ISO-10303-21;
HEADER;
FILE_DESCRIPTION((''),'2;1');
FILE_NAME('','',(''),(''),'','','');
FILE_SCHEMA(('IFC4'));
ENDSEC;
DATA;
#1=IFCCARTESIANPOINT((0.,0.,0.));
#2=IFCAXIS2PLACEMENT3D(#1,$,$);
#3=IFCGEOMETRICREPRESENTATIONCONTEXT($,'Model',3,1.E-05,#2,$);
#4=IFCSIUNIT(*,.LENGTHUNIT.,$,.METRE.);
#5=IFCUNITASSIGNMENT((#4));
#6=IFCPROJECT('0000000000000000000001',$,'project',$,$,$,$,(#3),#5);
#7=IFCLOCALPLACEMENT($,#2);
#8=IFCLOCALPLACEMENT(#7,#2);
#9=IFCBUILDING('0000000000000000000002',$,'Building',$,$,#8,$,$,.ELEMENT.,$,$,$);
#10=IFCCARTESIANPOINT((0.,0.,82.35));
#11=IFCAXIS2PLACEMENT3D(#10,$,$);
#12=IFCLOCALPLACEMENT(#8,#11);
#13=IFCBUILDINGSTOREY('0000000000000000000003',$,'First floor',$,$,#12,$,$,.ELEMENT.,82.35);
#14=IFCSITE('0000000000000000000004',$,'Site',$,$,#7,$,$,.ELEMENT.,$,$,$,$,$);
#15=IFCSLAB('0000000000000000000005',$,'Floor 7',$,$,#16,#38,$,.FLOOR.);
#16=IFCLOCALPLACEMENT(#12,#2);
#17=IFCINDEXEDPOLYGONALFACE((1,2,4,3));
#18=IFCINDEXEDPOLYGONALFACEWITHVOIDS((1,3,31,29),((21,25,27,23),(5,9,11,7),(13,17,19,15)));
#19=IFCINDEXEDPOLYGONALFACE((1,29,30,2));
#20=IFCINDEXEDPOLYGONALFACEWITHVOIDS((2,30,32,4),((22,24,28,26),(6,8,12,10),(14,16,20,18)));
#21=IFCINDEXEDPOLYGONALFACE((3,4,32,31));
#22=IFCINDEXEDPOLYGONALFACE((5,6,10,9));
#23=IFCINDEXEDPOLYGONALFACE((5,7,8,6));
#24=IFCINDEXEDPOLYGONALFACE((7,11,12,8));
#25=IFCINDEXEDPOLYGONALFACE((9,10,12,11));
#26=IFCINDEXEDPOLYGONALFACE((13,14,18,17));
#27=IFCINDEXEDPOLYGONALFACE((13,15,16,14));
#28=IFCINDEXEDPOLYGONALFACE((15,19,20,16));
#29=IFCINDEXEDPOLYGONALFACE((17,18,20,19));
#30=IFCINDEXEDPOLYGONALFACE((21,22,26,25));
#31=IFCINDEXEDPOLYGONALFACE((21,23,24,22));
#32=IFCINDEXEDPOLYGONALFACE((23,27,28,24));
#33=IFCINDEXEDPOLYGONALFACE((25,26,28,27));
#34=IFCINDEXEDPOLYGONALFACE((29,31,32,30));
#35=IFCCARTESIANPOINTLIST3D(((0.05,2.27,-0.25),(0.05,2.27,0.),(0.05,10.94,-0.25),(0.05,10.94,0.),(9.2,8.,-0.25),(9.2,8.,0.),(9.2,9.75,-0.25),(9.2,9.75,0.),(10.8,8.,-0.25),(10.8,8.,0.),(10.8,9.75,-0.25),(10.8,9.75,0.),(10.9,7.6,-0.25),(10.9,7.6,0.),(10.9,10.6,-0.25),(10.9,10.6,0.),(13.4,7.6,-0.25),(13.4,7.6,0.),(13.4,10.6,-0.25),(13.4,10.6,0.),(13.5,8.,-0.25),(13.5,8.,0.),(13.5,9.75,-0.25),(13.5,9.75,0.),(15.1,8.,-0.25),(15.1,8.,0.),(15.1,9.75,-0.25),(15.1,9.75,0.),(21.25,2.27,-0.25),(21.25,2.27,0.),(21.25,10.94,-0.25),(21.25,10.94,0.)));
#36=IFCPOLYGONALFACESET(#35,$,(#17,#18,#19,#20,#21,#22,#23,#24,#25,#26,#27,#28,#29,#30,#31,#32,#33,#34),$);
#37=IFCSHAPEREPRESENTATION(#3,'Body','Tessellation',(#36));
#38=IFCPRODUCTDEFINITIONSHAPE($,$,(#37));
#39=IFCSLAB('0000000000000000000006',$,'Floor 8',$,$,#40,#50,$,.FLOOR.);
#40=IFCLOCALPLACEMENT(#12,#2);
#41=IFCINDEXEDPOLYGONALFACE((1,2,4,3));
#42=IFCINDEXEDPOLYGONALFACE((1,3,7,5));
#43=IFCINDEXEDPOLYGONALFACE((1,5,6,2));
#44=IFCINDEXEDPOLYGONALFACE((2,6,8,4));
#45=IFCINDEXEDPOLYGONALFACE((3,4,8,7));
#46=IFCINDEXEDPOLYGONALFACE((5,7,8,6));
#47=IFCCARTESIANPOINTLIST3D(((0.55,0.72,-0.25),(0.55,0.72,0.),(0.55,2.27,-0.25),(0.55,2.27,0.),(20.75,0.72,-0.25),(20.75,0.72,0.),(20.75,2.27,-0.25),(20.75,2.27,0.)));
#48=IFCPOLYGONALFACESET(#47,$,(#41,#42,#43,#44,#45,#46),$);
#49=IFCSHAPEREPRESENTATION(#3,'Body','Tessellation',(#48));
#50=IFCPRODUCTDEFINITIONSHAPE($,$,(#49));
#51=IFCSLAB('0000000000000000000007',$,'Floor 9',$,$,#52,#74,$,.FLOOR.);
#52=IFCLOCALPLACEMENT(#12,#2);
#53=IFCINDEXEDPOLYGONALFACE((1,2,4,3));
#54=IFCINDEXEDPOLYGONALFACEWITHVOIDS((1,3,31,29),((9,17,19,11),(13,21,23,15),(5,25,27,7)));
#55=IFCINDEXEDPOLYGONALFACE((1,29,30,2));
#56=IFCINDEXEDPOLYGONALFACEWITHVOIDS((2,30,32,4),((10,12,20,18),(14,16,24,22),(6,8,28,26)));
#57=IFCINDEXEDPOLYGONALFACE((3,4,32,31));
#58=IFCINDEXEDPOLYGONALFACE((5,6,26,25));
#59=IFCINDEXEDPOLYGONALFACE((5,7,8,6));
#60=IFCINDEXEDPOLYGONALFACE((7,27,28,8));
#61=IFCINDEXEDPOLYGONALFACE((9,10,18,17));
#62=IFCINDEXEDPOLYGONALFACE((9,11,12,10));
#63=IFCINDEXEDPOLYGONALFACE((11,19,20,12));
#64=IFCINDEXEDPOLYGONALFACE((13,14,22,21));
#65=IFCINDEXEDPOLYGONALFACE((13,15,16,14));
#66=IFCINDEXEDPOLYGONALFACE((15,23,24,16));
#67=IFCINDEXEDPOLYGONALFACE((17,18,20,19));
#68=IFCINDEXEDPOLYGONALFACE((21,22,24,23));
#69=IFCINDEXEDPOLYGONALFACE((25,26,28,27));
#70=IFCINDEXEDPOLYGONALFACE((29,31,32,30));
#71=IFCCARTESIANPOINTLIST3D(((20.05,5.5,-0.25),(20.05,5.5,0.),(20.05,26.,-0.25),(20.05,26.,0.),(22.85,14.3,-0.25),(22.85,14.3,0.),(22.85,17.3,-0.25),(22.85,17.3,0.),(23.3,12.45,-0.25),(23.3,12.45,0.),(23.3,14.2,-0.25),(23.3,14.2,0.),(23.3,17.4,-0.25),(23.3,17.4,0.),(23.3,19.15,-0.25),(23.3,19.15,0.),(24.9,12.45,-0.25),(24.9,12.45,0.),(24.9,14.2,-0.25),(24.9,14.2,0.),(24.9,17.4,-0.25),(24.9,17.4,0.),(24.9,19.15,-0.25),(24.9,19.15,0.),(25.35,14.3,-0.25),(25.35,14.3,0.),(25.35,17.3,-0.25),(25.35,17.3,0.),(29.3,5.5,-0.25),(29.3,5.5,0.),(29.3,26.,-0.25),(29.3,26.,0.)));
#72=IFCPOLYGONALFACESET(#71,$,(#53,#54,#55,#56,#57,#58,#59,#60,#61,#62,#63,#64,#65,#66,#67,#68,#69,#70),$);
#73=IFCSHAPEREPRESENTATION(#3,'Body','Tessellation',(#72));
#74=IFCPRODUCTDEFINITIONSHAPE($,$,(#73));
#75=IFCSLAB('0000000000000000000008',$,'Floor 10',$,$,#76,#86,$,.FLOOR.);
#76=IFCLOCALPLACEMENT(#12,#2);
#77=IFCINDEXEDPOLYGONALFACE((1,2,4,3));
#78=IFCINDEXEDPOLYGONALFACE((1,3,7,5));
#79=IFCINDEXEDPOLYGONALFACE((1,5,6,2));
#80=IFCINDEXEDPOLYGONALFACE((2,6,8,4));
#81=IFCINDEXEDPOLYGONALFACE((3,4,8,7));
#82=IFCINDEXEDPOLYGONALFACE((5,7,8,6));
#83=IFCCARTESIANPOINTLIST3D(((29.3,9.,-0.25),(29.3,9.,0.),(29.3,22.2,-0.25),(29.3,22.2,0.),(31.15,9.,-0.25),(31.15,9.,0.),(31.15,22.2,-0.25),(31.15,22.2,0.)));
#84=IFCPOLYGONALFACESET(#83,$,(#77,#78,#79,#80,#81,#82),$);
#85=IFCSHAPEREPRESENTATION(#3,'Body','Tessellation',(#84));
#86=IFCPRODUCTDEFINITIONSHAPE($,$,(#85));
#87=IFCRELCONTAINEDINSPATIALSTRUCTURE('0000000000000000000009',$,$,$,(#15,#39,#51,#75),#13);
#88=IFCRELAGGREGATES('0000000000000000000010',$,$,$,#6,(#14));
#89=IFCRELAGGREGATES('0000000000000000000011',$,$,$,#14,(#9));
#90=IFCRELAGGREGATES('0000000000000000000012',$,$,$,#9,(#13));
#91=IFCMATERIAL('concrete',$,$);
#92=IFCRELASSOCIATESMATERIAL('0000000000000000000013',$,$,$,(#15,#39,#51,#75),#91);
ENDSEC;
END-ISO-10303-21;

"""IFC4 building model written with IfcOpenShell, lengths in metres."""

from ifc_helpers import new_model, si_unit, frame, origin, place, context, project, spatial, polyline, outline, extrude, material, element, save


model = new_model("IFC4")

# Units and contexts
model_context = context("Model", 3, precision=1e-05, world=origin())
ifc_project = project(units=[si_unit("LENGTHUNIT", "METRE")], contexts=[model_context])

# Site, building, storey
site_placement = place(None, origin())
site = spatial("IfcSite", under=ifc_project, at=site_placement, Name="Site", CompositionType="ELEMENT")
building_placement = place(site_placement, origin())
building = spatial("IfcBuilding", under=site, at=building_placement, Name="Building", CompositionType="ELEMENT")
storey_placement = place(building_placement, frame((0.0, 0.0, 82.35)))
storey = spatial("IfcBuildingStorey", under=building, at=storey_placement, Name="First floor", CompositionType="ELEMENT", Elevation=82.35)

# Slabs
ifc_material = material(Name="concrete")
slab_1_placement = place(storey_placement, frame((0.0, 0.0, -0.25), z_axis=(0.0, 0.0, 1.0), x_axis=(1.0, 0.0, 0.0)))
element("IfcSlab", 1, at=slab_1_placement, inside=storey, material=ifc_material, Name="Floor 7", PredefinedType="FLOOR", context=model_context, shape_type="SweptSolid", body=[
    extrude(outline(polyline([(0.05, 2.27), (21.25, 2.27), (21.25, 10.94), (0.05, 10.94), (0.05, 2.27)]), holes=[polyline([(10.9, 7.6), (13.4, 7.6), (13.4, 10.6), (10.9, 10.6), (10.9, 7.6)]), polyline([(9.2, 8.0), (10.8, 8.0), (10.8, 9.75), (9.2, 9.75), (9.2, 8.0)]), polyline([(13.5, 8.0), (15.1, 8.0), (15.1, 9.75), (13.5, 9.75), (13.5, 8.0)])]), origin(), (0.0, 0.0, 1.0), 0.25),
])
slab_2_placement = place(storey_placement, frame((0.0, 0.0, -0.25), z_axis=(0.0, 0.0, 1.0), x_axis=(1.0, 0.0, 0.0)))
element("IfcSlab", 2, at=slab_2_placement, inside=storey, material=ifc_material, Name="Floor 8", PredefinedType="FLOOR", context=model_context, shape_type="SweptSolid", body=[
    extrude(outline(polyline([(0.55, 0.72), (20.75, 0.72), (20.75, 2.27), (0.55, 2.27), (0.55, 0.72)])), origin(), (0.0, 0.0, 1.0), 0.25),
])
slab_3_placement = place(storey_placement, frame((0.0, 0.0, -0.25), z_axis=(0.0, 0.0, 1.0), x_axis=(1.0, 0.0, 0.0)))
element("IfcSlab", 3, at=slab_3_placement, inside=storey, material=ifc_material, Name="Floor 9", PredefinedType="FLOOR", context=model_context, shape_type="SweptSolid", body=[
    extrude(outline(polyline([(20.05, 5.5), (29.3, 5.5), (29.3, 26.0), (20.05, 26.0), (20.05, 5.5)]), holes=[polyline([(22.85, 14.3), (25.35, 14.3), (25.35, 17.3), (22.85, 17.3), (22.85, 14.3)]), polyline([(23.3, 17.4), (24.9, 17.4), (24.9, 19.15), (23.3, 19.15), (23.3, 17.4)]), polyline([(23.3, 12.45), (24.9, 12.45), (24.9, 14.2), (23.3, 14.2), (23.3, 12.45)])]), origin(), (0.0, 0.0, 1.0), 0.25),
])
slab_4_placement = place(storey_placement, frame((0.0, 0.0, -0.25), z_axis=(0.0, 0.0, 1.0), x_axis=(1.0, 0.0, 0.0)))
element("IfcSlab", 4, at=slab_4_placement, inside=storey, material=ifc_material, Name="Floor 10", PredefinedType="FLOOR", context=model_context, shape_type="SweptSolid", body=[
    extrude(outline(polyline([(29.3, 9.0), (31.15, 9.0), (31.15, 22.2), (29.3, 22.2), (29.3, 9.0)])), origin(), (0.0, 0.0, 1.0), 0.25),
])

save(model, "model.ifc")
